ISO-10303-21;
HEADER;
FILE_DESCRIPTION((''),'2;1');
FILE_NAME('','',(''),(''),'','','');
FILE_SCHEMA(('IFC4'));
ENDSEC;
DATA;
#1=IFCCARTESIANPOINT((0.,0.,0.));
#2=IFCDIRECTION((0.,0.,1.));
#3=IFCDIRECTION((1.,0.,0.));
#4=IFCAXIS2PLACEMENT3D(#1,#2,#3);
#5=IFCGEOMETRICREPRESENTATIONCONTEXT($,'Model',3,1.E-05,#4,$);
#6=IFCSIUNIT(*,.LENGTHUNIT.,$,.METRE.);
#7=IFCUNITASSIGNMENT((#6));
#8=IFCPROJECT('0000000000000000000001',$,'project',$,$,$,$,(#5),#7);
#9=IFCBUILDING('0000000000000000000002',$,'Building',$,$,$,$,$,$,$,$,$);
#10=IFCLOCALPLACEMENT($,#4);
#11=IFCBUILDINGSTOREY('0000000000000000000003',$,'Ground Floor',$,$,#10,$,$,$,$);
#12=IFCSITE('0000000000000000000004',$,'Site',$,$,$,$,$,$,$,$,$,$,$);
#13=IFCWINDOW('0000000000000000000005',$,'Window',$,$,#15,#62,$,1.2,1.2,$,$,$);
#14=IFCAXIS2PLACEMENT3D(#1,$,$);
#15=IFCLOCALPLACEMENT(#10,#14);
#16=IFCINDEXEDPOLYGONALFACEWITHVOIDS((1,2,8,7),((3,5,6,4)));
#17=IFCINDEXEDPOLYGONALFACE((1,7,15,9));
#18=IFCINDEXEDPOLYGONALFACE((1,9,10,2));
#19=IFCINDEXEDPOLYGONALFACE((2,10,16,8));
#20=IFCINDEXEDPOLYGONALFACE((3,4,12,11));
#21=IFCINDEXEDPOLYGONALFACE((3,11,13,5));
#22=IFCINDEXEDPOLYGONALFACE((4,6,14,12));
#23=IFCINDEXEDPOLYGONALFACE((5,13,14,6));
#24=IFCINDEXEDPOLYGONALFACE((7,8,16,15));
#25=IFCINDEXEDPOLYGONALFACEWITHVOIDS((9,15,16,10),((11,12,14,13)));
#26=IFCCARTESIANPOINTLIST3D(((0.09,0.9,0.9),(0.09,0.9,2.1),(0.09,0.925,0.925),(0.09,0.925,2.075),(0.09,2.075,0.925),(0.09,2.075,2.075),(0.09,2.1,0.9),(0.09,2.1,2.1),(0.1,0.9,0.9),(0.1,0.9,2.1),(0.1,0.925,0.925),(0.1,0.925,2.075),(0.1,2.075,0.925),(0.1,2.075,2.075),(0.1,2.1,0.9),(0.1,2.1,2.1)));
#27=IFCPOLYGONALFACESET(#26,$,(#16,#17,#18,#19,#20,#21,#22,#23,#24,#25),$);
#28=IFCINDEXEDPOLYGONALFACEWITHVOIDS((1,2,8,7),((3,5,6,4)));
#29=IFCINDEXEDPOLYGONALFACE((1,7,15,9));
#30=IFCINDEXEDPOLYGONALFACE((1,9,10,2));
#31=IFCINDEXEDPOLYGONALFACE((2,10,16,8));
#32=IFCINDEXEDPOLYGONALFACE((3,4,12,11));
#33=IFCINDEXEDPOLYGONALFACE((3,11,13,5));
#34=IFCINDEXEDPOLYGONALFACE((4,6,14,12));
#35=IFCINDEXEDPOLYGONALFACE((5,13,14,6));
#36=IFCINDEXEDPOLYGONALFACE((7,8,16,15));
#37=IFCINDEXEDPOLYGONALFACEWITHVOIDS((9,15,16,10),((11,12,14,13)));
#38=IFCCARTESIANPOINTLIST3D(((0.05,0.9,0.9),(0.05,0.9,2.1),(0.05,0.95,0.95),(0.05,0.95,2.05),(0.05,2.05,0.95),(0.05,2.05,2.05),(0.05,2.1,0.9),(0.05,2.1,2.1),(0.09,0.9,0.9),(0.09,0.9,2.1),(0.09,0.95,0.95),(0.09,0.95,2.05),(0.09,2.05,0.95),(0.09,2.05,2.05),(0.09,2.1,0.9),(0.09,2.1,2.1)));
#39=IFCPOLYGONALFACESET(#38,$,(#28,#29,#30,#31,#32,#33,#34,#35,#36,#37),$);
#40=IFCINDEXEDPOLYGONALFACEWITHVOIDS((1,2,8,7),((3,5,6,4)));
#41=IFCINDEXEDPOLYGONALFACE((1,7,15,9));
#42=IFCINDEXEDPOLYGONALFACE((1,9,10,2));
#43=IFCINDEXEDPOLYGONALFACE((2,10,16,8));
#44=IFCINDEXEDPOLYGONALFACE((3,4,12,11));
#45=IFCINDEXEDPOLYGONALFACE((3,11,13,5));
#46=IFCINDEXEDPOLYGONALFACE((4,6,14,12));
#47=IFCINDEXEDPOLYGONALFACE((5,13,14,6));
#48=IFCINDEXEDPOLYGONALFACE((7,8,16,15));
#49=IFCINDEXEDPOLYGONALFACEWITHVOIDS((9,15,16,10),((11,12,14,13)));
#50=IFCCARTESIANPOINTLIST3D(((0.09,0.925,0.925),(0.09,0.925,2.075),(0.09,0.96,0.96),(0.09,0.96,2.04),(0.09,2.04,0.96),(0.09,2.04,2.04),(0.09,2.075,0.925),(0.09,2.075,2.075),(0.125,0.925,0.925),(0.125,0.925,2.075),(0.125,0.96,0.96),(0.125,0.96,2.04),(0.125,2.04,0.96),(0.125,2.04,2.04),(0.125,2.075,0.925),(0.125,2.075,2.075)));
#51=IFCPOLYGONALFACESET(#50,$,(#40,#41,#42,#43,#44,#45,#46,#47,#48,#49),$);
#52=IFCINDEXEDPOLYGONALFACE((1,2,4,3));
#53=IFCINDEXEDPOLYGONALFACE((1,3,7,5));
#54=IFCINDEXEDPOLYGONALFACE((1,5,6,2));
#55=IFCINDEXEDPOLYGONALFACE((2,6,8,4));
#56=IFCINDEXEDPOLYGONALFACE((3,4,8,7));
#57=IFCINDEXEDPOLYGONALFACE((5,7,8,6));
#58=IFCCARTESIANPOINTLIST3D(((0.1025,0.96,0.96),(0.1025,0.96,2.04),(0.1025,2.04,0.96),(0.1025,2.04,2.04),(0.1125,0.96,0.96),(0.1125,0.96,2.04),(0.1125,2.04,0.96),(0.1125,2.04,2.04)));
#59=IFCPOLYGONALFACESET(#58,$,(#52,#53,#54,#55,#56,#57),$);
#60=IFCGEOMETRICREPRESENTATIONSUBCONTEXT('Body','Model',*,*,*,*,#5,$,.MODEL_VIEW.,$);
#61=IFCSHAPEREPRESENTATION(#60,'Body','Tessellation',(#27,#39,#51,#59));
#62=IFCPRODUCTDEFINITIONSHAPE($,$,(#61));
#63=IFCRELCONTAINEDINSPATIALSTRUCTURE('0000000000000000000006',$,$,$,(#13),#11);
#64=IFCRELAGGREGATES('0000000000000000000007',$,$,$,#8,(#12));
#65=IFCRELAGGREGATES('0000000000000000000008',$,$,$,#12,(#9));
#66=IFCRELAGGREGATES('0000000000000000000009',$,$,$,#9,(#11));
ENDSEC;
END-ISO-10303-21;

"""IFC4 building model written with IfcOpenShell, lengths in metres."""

from ifc_helpers import new_model, si_unit, frame, origin_with_axes, place, context, subcontext, project, spatial, line, indexed_curve, outline, extrude, element, save


model = new_model("IFC4")

# Units and contexts
model_context = context("Model", 3, precision=1e-05, world=origin_with_axes())
body_context = subcontext(model_context, "Body", "Model", "MODEL_VIEW")
ifc_project = project(units=[si_unit("LENGTHUNIT", "METRE")], contexts=[model_context])

# Site, building, storey
site = spatial("IfcSite", under=ifc_project, Name="Site")
building = spatial("IfcBuilding", under=site, Name="Building")
storey_placement = place(None, origin_with_axes())
storey = spatial("IfcBuildingStorey", under=building, at=storey_placement, Name="Ground Floor")

# Window
window_1_placement = place(storey_placement, frame((0.0, 2.1, 0.9), z_axis=(0.0, 0.0, 1.0), x_axis=(0.0, -1.0, 0.0)))
element("IfcWindow", 1, at=window_1_placement, inside=storey, Name="Window", OverallHeight=1.2, OverallWidth=1.2, context=body_context, shape_type="SweptSolid", body=[
    extrude(outline(indexed_curve([(0.0, 0.0), (1.2, 0.0), (1.2, 1.2), (0.0, 1.2)], segments=[line(1, 2, 3, 4, 1)]), holes=[indexed_curve([(0.025, 0.025), (1.175, 0.025), (1.175, 1.175), (0.025, 1.175)], segments=[line(1, 2, 3, 4, 1)])]), frame((0.0, 0.09, 0.0), z_axis=(0.0, -1.0, 0.0), x_axis=(1.0, 0.0, 0.0)), (0.0, 0.0, -1.0), 0.01),
    extrude(outline(indexed_curve([(0.0, 0.0), (1.2, 0.0), (1.2, 1.2), (0.0, 1.2)], segments=[line(1, 2, 3, 4, 1)]), holes=[indexed_curve([(0.05, 0.05), (1.15, 0.05), (1.15, 1.15), (0.05, 1.15)], segments=[line(1, 2, 3, 4, 1)])]), frame((0.0, 0.05, 0.0), z_axis=(0.0, -1.0, 0.0), x_axis=(1.0, 0.0, 0.0)), (0.0, 0.0, -1.0), 0.04),
    extrude(outline(indexed_curve([(0.0, 0.0), (1.15, 0.0), (1.15, 1.15), (0.0, 1.15)], segments=[line(1, 2, 3, 4, 1)]), holes=[indexed_curve([(0.035, 0.035), (1.115, 0.035), (1.115, 1.115), (0.035, 1.115)], segments=[line(1, 2, 3, 4, 1)])]), frame((0.025, 0.09, 0.025), z_axis=(0.0, -1.0, 0.0), x_axis=(1.0, 0.0, 0.0)), (0.0, 0.0, -1.0), 0.035),
    extrude(outline(indexed_curve([(0.035, 0.035), (1.115, 0.035), (1.115, 1.115), (0.035, 1.115)], segments=[line(1, 2, 3, 4, 1)])), frame((0.025, 0.1025, 0.025), z_axis=(0.0, -1.0, 0.0), x_axis=(1.0, 0.0, 0.0)), (0.0, 0.0, -1.0), 0.01),
])

save(model, "model.ifc")
